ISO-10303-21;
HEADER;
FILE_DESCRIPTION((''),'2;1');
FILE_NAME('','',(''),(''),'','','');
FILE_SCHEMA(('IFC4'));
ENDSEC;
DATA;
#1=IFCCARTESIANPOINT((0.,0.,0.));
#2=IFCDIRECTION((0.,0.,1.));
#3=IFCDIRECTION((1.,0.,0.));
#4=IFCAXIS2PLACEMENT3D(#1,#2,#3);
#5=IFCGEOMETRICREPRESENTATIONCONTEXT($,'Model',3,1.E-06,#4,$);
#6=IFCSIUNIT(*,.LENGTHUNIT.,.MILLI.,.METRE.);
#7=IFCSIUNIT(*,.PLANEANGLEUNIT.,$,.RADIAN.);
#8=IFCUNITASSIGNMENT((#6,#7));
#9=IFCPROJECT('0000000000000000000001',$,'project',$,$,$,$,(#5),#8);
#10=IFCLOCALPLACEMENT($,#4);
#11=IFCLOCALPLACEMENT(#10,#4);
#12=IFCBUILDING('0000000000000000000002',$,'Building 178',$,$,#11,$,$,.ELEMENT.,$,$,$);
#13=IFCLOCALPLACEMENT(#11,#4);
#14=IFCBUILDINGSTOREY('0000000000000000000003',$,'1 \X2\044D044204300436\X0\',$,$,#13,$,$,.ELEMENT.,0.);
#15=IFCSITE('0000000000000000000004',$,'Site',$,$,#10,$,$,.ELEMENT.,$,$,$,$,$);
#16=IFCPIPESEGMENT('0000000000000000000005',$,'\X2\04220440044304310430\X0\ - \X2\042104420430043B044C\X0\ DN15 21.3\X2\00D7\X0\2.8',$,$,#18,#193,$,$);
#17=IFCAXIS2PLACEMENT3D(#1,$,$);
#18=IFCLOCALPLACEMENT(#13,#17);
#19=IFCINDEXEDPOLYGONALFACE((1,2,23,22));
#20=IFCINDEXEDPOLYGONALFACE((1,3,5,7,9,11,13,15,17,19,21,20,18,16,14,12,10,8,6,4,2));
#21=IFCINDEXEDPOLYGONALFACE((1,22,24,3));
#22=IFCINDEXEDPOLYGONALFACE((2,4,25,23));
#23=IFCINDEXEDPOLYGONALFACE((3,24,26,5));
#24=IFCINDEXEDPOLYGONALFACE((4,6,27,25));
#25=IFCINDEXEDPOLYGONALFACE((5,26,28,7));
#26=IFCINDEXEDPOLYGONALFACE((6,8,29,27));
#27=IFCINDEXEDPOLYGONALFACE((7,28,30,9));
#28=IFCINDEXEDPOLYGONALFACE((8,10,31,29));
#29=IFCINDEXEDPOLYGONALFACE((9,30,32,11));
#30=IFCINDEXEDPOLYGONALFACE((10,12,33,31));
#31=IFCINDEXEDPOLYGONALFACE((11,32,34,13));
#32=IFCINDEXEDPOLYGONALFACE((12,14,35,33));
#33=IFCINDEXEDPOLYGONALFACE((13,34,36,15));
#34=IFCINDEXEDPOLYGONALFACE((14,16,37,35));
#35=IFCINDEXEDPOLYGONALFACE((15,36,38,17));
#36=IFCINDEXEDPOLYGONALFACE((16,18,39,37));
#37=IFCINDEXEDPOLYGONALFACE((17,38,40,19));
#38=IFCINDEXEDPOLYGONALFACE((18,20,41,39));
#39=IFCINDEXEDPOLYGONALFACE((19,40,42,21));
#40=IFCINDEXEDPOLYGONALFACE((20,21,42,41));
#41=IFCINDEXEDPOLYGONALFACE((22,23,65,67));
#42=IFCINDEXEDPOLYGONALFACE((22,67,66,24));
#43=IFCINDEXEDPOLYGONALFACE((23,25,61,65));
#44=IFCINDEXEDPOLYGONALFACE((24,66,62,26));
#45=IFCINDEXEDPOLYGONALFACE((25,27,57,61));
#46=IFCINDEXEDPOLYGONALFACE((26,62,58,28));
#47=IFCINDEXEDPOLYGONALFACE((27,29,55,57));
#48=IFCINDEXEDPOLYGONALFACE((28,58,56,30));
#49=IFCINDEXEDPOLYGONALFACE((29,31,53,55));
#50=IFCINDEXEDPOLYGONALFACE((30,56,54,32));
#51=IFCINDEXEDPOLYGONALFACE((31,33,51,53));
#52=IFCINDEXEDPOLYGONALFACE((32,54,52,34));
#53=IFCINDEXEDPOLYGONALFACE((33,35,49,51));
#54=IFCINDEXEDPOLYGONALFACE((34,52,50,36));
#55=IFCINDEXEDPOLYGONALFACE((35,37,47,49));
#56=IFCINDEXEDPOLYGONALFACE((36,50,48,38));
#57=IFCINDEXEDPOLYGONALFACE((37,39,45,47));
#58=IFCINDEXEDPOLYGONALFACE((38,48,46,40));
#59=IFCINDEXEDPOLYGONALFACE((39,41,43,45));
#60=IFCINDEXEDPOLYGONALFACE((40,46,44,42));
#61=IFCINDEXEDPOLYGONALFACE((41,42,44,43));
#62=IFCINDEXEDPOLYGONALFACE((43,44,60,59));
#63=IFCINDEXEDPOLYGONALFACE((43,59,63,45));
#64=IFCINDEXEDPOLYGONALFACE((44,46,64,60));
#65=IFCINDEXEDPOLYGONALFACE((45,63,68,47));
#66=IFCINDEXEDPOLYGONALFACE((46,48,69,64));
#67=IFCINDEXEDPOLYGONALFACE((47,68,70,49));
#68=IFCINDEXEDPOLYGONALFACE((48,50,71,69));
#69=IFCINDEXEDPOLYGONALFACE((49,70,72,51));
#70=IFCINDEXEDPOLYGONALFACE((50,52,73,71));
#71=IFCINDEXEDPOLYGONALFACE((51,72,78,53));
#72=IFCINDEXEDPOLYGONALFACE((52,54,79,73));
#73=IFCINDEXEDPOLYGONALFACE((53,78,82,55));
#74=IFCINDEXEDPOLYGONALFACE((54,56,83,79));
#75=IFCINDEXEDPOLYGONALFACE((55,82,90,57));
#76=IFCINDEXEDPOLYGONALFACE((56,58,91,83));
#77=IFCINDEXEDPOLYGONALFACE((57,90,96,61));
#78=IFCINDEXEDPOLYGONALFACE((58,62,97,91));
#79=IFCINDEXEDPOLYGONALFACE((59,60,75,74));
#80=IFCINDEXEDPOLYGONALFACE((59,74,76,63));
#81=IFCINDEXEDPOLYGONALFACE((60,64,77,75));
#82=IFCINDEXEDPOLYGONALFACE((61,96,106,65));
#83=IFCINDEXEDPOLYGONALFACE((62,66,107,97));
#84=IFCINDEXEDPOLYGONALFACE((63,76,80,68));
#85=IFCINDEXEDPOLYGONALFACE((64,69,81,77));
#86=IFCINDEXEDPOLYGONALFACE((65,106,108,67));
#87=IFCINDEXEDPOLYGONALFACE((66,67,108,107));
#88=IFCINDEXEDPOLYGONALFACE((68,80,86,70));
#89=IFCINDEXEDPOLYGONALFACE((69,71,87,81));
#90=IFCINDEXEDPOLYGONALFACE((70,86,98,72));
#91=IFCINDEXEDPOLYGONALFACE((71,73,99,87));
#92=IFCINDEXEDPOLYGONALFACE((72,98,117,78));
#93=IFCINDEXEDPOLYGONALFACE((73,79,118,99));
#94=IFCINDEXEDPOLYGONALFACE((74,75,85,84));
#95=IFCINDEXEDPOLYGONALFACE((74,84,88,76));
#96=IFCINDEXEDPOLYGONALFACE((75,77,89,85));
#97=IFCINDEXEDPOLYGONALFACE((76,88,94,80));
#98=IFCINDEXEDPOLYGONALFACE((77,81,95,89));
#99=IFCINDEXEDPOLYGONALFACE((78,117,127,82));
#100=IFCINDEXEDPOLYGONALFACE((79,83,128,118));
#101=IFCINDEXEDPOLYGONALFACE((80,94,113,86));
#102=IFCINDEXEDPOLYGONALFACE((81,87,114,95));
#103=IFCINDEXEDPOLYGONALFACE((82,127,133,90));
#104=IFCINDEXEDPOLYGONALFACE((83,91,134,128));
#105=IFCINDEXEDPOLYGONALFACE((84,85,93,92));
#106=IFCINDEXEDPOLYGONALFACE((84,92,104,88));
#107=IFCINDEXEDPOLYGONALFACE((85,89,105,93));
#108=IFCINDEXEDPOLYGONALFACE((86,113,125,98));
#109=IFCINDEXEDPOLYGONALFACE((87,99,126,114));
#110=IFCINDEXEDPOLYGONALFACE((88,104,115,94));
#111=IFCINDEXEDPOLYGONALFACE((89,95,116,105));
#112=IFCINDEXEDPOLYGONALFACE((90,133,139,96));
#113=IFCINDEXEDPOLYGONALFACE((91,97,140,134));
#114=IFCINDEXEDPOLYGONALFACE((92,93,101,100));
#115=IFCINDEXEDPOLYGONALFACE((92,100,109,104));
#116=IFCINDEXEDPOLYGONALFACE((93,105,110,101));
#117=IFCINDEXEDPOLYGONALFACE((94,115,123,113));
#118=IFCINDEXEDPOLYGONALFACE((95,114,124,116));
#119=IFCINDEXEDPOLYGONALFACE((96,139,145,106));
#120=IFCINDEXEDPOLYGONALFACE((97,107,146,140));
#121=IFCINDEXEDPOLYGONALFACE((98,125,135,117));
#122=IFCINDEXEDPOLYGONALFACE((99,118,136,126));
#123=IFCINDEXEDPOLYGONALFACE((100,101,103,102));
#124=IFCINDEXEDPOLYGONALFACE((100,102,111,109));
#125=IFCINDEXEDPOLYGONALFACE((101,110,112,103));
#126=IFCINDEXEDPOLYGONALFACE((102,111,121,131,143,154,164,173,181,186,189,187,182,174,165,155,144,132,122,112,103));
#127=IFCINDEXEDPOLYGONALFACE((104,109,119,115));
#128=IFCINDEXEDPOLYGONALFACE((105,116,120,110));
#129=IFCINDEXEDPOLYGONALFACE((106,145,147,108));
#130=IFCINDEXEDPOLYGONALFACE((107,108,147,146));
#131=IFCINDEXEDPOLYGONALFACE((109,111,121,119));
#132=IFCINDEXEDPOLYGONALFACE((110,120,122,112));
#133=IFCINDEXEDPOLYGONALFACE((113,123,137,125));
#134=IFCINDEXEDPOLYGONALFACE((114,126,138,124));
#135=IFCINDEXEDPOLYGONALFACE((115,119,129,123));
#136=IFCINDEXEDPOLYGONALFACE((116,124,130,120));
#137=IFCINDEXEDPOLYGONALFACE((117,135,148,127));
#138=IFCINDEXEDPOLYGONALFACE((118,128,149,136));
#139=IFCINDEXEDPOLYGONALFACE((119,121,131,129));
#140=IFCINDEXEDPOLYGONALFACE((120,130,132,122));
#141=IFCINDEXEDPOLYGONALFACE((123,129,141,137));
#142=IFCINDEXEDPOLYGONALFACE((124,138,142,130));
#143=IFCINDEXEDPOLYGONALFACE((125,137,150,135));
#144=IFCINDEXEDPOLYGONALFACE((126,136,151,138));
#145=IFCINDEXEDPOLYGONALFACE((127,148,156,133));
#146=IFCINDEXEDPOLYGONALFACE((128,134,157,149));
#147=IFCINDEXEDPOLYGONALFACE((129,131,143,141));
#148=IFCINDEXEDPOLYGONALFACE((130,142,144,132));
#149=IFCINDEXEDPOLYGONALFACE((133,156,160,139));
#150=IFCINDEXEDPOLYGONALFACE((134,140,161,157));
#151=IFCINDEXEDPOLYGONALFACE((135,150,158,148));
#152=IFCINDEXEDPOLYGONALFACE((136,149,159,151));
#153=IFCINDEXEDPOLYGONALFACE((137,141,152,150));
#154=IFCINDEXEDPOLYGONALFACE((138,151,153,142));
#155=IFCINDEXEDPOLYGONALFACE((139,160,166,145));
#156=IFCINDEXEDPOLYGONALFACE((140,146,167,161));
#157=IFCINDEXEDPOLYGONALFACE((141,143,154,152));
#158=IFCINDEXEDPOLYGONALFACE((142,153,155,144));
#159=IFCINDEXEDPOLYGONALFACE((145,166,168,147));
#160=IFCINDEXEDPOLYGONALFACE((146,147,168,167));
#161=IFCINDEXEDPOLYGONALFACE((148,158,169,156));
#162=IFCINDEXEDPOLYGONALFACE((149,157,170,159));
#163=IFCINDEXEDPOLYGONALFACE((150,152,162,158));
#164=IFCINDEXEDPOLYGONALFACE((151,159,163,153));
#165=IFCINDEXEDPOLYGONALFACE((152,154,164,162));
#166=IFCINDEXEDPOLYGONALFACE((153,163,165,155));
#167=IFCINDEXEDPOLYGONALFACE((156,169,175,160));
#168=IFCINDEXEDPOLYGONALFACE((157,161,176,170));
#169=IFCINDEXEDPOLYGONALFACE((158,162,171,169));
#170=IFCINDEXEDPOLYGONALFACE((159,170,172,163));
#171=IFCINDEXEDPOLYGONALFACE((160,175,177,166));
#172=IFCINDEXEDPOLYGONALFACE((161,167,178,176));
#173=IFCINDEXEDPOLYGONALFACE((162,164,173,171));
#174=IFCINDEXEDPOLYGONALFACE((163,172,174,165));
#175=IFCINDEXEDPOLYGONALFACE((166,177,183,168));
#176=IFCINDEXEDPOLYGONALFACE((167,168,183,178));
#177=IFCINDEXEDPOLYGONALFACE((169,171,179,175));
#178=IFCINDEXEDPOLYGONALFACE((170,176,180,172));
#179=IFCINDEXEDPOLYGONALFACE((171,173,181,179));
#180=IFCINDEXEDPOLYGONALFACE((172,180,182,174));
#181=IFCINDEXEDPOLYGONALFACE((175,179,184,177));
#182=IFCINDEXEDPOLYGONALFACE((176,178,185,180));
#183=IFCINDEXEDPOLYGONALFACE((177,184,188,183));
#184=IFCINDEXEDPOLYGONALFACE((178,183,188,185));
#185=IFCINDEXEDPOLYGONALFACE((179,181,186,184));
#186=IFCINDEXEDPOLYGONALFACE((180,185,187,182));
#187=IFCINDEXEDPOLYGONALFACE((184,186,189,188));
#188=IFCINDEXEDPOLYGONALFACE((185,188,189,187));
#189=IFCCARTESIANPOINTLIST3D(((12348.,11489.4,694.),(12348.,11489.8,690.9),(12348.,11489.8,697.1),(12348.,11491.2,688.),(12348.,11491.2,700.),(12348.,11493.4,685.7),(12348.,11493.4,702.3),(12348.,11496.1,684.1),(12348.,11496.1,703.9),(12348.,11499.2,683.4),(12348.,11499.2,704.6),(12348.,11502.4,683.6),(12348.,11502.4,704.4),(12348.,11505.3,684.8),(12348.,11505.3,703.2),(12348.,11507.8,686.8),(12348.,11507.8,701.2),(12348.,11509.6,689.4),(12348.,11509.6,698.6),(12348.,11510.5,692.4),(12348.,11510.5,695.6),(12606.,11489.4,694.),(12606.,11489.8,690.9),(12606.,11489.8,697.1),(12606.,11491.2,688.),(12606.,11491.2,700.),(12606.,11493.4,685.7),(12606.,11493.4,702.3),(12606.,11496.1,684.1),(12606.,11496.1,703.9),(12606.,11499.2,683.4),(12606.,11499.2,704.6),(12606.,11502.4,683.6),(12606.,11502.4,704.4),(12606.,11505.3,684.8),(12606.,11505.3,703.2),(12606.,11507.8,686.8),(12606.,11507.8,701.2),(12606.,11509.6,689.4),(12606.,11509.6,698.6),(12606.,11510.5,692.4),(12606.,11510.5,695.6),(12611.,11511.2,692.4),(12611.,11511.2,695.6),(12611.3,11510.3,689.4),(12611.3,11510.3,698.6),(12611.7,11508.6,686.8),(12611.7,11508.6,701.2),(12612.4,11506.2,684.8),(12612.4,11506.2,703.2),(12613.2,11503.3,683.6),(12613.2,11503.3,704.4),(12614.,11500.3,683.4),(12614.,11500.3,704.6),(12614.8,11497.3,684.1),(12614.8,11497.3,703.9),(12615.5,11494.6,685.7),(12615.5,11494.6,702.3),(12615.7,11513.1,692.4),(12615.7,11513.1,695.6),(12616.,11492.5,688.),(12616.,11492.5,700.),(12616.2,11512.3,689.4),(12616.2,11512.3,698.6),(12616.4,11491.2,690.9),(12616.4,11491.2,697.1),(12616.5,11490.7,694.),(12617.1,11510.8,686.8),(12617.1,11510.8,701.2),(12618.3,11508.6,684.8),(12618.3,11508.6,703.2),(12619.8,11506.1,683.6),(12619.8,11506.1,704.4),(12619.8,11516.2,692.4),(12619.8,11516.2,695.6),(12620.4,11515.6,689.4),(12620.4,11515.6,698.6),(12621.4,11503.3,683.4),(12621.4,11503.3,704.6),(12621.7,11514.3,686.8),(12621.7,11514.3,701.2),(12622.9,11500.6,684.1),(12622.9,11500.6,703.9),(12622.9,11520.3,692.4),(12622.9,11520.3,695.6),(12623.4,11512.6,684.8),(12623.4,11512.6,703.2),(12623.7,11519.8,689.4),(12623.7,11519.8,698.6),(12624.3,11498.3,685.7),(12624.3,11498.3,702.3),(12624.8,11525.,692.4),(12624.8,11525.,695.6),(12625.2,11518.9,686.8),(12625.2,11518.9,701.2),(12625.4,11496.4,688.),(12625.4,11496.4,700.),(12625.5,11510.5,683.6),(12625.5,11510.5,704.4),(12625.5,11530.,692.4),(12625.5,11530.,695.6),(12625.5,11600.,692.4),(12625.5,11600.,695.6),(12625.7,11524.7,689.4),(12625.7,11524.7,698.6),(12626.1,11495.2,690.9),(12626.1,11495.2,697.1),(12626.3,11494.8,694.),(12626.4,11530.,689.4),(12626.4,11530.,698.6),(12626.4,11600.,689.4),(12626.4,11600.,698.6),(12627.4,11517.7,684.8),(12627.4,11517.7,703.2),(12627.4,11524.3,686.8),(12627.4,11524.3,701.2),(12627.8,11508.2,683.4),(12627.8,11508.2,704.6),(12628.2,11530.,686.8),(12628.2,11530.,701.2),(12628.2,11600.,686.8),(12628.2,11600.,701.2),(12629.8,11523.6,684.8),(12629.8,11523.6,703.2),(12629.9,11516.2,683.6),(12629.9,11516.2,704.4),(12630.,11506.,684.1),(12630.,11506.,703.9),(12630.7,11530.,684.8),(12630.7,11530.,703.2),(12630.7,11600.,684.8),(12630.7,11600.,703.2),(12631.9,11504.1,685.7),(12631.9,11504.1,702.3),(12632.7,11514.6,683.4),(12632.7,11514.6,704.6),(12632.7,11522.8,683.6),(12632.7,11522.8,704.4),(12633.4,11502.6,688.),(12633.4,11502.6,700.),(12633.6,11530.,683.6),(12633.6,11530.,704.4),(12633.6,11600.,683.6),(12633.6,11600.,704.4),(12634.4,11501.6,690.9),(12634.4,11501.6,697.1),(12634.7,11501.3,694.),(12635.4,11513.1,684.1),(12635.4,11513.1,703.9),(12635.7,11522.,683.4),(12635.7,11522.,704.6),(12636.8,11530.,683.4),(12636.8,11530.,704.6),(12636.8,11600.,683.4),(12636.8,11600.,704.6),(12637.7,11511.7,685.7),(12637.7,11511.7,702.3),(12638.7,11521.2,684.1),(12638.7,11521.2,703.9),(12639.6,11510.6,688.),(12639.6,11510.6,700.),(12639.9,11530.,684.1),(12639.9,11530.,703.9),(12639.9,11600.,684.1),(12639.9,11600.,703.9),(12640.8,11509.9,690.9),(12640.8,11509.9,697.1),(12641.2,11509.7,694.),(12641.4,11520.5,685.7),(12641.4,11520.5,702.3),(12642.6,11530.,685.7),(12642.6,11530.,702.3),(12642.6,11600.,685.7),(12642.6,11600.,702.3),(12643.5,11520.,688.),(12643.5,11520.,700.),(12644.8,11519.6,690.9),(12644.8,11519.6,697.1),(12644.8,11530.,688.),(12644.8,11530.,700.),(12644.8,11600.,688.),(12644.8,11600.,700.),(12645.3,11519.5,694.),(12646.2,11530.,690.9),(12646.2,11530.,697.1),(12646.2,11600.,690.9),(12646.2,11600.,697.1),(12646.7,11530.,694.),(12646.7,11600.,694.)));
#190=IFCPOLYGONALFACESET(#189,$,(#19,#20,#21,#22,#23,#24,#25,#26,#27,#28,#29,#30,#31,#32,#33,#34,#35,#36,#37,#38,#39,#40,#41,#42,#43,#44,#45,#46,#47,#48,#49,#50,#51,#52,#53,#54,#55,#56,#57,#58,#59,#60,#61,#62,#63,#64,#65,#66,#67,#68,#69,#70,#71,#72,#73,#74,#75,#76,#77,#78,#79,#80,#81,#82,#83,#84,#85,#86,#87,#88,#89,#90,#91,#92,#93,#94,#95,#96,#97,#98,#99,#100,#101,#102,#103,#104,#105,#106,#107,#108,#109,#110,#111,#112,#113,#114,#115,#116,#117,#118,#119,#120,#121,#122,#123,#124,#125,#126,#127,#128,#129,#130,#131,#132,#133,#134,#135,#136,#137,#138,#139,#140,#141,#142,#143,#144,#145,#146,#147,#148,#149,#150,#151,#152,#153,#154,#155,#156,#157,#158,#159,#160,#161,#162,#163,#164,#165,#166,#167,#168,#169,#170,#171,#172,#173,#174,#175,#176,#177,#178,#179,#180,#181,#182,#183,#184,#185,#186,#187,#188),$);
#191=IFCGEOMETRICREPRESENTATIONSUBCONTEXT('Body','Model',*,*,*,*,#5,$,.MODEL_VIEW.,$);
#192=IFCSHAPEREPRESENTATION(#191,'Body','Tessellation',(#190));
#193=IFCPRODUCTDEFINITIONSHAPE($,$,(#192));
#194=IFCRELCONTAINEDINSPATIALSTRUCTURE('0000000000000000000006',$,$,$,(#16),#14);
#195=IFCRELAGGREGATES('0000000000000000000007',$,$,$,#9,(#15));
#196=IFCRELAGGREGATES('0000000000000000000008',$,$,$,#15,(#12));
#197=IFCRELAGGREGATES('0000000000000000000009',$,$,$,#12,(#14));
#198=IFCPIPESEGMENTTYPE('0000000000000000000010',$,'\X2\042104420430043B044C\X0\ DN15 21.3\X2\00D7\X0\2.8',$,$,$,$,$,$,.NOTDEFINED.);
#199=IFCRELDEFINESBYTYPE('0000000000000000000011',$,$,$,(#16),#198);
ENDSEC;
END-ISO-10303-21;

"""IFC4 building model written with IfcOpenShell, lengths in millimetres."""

from ifc_helpers import new_model, entity, si_unit, frame, origin_with_axes, place, context, subcontext, project, spatial, source, transform, mapped, type_object, element, save


model = new_model("IFC4")

# Units and contexts
model_context = context("Model", 3, precision=1e-06, world=origin_with_axes())
body_context = subcontext(model_context, "Body", "Model", "MODEL_VIEW")
ifc_project = project(units=[si_unit("LENGTHUNIT", "METRE", prefix="MILLI"), si_unit("PLANEANGLEUNIT", "RADIAN")], contexts=[model_context])

# Site, building, storey
site_placement = place(None, origin_with_axes())
site = spatial("IfcSite", under=ifc_project, at=site_placement, Name="Site", CompositionType="ELEMENT")
building_placement = place(site_placement, origin_with_axes())
building = spatial("IfcBuilding", under=site, at=building_placement, Name="Building 178", CompositionType="ELEMENT")
storey_placement = place(building_placement, origin_with_axes())
storey = spatial("IfcBuildingStorey", under=building, at=storey_placement, Name="1 этаж", CompositionType="ELEMENT", Elevation=0.0)

# Pipe segment
pipe_segment_type = type_object("IfcPipeSegmentType", Name="Сталь DN15 21.3×2.8", PredefinedType="NOTDEFINED")
shared_shape_1 = source(origin_with_axes(), body_context, "Body", "AdvancedSweptSolid", [
    entity("IfcSweptDiskSolid", entity("IfcIndexedPolyCurve", entity("IfcCartesianPointList3D", [[0.0, 0.0, 0.0], [0.0, 0.0, -70.0], [8.8, 0.0, -91.2], [30.0, 0.0, -100.0], [288.0, 0.0, -100.0]]), [entity("IfcLineIndex", [1, 2]), entity("IfcArcIndex", [2, 3, 4]), entity("IfcLineIndex", [4, 5])]), 10.7),
])
for number, where, z_axis, x_axis, name in (
    (1, (12636.0, 11600.0, 694.0), (0.0, 1.0, 0.0), (-1.0, 0.0, 0.0), "Труба - Сталь DN15 21.3×2.8"),
):
    element("IfcPipeSegment", number, at=place(storey_placement, frame(where, z_axis=z_axis, x_axis=x_axis)), inside=storey, type_object=pipe_segment_type, Name=name, context=body_context, shape_type="MappedRepresentation", body=[
        mapped(shared_shape_1, transform((0.0, 0.0, 0.0), x_axis=(1.0, 0.0, 0.0), y_axis=(0.0, 1.0, 0.0), z_axis=(0.0, 0.0, 1.0), scale=1.0)),
    ])

save(model, "model.ifc")
